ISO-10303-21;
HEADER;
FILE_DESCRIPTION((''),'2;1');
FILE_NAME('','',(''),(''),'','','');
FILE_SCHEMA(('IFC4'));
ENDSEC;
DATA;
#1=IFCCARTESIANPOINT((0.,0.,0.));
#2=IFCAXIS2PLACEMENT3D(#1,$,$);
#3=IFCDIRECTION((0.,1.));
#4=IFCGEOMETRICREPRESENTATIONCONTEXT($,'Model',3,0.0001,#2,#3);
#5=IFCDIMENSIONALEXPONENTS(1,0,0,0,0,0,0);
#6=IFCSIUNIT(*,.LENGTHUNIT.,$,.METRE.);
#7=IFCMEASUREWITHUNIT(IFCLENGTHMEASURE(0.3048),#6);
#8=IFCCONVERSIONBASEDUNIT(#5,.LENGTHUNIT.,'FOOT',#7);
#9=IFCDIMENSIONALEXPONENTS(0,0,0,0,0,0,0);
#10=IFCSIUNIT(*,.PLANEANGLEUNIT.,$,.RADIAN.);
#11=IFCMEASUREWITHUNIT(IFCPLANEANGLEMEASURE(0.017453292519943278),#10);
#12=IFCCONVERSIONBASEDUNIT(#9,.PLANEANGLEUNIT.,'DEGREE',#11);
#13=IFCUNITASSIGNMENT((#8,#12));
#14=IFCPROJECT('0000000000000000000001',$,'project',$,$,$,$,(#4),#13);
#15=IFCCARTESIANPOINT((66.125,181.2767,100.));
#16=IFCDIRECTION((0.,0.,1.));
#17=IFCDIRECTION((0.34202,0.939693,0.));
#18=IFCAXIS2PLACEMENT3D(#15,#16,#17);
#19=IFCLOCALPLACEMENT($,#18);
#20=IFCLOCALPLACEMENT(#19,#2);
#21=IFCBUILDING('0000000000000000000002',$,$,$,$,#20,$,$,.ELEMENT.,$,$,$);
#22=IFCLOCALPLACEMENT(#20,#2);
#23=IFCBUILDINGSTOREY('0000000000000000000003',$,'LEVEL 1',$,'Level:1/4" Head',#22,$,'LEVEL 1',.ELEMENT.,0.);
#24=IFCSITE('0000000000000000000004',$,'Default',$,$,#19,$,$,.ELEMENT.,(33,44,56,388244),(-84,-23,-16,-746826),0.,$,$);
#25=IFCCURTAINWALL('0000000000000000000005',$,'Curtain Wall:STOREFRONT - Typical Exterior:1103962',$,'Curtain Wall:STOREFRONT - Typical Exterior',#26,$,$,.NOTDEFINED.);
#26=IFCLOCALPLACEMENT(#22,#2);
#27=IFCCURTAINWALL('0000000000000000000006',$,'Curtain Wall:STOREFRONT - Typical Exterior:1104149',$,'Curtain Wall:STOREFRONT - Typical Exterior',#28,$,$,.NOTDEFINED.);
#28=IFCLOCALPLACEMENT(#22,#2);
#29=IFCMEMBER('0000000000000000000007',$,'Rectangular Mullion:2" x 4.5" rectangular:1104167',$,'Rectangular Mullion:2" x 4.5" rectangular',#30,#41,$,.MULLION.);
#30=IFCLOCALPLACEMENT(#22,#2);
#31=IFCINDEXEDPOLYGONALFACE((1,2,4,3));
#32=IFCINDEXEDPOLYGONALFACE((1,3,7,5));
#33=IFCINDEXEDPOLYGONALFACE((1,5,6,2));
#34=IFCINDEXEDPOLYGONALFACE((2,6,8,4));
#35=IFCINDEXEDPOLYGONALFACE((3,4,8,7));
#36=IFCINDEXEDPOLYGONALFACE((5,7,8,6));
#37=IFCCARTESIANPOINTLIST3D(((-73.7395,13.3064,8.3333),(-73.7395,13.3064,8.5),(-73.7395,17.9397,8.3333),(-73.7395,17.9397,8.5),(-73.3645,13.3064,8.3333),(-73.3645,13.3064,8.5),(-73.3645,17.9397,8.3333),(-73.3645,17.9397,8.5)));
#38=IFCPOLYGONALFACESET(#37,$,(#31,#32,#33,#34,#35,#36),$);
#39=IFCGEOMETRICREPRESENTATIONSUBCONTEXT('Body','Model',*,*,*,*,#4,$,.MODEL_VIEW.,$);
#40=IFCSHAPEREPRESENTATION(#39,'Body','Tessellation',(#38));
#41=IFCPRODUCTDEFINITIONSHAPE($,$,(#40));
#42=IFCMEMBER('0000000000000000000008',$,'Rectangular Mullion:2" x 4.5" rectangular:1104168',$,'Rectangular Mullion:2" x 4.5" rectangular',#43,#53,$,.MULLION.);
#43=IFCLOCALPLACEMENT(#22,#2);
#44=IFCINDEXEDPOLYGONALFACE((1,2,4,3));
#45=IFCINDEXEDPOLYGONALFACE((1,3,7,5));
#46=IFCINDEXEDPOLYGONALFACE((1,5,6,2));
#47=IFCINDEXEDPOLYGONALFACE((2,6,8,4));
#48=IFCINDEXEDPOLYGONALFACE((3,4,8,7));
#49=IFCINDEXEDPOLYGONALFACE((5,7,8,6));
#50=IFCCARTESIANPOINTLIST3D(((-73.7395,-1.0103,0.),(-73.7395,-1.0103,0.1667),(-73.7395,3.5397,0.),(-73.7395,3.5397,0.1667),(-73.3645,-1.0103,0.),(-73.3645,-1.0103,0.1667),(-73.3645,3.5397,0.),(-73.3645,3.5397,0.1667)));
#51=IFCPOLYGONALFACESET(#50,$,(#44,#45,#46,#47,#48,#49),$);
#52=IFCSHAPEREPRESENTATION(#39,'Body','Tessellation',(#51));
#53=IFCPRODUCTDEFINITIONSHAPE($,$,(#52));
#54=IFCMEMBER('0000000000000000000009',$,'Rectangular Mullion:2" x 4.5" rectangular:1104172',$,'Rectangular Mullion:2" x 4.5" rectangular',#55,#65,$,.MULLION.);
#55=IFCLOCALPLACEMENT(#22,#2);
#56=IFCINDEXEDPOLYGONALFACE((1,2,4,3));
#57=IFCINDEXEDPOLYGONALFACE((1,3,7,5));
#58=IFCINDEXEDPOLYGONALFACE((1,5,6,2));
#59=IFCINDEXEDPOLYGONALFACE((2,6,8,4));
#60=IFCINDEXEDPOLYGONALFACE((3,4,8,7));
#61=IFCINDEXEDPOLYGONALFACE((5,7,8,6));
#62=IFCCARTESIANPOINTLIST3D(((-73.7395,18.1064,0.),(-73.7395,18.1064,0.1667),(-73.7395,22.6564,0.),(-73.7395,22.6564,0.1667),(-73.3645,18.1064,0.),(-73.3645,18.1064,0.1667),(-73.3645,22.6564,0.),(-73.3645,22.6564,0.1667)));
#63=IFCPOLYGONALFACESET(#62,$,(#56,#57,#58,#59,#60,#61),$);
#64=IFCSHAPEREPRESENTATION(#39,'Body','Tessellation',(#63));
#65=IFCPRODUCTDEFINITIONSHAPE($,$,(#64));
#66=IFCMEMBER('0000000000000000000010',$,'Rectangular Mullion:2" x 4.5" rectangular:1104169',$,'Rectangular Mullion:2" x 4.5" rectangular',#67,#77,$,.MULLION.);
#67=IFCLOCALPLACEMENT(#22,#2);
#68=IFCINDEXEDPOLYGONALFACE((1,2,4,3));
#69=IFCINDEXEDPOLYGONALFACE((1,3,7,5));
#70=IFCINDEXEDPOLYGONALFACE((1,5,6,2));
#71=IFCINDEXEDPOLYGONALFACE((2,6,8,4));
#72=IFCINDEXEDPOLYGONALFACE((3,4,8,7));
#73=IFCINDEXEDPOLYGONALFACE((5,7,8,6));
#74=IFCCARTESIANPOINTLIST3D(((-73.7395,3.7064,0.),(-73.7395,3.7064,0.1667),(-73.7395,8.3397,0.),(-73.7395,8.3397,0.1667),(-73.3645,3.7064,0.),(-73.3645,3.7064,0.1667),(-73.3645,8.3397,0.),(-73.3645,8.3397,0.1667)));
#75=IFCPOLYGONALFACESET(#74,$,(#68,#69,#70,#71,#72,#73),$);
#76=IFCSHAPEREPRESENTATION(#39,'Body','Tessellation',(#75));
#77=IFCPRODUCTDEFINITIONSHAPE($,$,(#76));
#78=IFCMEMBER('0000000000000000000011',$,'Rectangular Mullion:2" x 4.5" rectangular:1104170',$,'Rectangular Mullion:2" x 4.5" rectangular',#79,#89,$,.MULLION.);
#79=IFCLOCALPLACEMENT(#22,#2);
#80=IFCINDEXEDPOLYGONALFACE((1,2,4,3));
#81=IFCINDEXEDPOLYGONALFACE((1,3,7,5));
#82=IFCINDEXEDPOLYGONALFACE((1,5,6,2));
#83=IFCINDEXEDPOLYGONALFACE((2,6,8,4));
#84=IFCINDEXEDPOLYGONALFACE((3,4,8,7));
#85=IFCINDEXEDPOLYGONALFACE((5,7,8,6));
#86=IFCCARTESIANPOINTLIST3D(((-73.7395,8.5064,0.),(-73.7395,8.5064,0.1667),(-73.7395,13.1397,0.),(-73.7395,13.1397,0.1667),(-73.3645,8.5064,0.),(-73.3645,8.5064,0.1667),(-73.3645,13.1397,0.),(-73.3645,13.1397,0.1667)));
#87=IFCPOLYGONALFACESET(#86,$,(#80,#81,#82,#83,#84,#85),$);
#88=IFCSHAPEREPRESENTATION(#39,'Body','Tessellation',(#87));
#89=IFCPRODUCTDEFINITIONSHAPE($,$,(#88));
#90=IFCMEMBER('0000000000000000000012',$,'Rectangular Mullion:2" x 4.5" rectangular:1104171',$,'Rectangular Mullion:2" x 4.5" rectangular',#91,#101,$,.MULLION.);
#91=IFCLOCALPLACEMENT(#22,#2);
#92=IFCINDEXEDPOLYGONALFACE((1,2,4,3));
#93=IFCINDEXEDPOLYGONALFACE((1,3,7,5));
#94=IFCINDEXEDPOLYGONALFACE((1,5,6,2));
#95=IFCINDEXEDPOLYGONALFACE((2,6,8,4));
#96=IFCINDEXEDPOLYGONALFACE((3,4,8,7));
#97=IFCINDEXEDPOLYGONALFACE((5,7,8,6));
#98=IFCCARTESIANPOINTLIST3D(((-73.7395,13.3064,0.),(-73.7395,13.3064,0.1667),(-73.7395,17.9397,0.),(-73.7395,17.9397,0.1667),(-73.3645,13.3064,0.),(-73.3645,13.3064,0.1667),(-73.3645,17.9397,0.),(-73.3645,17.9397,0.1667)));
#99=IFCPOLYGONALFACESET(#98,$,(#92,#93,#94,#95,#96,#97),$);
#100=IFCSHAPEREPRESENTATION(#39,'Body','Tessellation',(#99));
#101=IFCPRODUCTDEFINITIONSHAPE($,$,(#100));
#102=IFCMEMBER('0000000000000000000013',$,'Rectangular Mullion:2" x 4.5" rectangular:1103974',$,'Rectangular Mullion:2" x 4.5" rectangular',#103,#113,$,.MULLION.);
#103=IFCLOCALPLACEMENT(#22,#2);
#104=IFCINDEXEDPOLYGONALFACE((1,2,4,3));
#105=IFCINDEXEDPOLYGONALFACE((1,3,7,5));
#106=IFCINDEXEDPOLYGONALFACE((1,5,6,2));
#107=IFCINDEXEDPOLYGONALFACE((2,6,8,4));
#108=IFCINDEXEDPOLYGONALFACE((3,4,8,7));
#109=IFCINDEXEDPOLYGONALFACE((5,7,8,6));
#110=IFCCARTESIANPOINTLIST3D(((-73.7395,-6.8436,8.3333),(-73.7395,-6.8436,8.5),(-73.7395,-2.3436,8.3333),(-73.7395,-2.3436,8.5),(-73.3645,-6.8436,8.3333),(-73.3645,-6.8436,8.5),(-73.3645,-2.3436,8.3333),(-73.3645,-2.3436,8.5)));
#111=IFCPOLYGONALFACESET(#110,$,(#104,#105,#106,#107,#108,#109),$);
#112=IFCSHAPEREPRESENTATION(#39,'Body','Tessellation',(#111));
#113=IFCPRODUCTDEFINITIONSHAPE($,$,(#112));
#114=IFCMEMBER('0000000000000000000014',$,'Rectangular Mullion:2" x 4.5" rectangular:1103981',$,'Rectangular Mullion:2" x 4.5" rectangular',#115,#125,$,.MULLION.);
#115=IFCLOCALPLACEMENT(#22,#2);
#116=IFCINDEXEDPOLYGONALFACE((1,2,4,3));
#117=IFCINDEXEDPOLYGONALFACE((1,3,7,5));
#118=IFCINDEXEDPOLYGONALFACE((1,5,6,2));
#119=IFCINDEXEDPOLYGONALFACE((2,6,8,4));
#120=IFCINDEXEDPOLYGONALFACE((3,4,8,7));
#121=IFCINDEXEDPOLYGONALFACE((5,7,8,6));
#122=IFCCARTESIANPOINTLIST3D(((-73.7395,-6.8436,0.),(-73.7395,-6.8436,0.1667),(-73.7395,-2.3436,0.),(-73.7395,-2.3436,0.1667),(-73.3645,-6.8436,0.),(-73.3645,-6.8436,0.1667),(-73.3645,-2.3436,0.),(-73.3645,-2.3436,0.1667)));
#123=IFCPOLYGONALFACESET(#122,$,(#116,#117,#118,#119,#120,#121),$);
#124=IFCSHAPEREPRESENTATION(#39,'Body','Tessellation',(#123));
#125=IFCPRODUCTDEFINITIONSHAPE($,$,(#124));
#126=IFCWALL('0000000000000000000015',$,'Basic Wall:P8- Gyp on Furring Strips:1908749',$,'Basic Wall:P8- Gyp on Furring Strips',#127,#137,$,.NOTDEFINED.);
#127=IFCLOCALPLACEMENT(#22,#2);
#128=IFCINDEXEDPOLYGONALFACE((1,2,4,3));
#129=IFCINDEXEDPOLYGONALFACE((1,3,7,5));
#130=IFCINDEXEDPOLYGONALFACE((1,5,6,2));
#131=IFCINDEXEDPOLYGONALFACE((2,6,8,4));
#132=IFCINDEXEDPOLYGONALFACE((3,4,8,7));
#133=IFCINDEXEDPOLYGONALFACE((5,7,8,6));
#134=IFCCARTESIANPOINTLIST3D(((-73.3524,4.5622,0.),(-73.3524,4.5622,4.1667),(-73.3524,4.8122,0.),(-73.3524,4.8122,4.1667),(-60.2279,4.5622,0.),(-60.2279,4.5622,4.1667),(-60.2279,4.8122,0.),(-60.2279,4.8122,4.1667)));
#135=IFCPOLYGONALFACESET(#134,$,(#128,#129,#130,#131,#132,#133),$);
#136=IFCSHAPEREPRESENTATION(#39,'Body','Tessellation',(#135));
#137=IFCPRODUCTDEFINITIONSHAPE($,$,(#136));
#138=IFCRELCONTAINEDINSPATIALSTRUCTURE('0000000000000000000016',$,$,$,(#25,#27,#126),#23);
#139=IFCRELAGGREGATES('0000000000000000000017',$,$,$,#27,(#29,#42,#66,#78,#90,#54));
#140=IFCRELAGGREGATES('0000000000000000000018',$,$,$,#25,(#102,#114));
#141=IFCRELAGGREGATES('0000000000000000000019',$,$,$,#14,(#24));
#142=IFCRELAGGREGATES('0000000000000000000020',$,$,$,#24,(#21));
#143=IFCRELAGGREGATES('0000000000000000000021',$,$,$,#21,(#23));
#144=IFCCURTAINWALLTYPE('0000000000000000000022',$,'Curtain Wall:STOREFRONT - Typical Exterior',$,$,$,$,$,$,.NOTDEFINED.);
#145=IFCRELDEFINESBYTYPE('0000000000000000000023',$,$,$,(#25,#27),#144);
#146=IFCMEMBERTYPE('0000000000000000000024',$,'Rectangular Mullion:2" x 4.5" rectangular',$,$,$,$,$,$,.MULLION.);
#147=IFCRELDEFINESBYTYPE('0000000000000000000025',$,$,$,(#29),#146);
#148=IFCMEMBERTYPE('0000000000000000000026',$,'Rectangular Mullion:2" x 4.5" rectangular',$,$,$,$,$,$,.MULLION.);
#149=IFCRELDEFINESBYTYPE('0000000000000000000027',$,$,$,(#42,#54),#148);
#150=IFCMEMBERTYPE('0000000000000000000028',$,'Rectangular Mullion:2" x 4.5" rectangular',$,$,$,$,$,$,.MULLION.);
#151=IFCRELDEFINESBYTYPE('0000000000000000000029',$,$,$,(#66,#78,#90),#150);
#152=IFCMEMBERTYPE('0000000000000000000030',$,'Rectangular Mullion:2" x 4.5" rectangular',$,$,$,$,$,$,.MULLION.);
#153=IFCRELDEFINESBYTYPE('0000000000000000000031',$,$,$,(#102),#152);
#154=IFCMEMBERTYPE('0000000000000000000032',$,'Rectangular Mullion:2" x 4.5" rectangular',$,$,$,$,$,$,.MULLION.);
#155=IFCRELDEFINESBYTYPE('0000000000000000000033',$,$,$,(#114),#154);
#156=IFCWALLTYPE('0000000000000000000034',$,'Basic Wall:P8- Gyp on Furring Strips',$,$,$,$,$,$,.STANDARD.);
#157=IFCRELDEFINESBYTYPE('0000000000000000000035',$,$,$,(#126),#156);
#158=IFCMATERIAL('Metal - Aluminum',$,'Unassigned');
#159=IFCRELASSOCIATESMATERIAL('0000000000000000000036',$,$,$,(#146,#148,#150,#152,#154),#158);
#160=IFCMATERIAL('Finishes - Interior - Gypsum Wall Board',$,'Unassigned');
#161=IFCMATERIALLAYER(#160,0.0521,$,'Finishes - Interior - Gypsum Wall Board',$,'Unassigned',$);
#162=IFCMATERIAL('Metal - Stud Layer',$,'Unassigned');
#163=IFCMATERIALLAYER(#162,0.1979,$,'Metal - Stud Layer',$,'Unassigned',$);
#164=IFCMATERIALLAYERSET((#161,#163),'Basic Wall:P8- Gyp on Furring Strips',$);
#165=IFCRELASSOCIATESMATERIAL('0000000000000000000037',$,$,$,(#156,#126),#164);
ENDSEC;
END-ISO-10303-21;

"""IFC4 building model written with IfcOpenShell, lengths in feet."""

from ifc_helpers import new_model, entity, si_unit, converted_unit, direction, frame, frame_2d, origin, origin_2d_with_axis, place, context, subcontext, project, spatial, rectangle, extrude, source, transform, mapped, material, layer, layer_set, layer_usage, material_profile, profile_set, type_object, type_shapes, element, aggregate, save


model = new_model("IFC4")

# Units and contexts
model_context = context("Model", 3, precision=0.0001, world=origin(), true_north=direction((0.0, 1.0)))
body_context = subcontext(model_context, "Body", "Model", "MODEL_VIEW")
ifc_project = project(units=[converted_unit("LENGTHUNIT", "FOOT", entity("IfcLengthMeasure", 0.3048), si_unit("LENGTHUNIT", "METRE"), dimensions=[1, 0, 0, 0, 0, 0, 0]), converted_unit("PLANEANGLEUNIT", "DEGREE", entity("IfcPlaneAngleMeasure", 0.017453292519943278), si_unit("PLANEANGLEUNIT", "RADIAN"), dimensions=[0, 0, 0, 0, 0, 0, 0])], contexts=[model_context])

# Site, building, storey
site_placement = place(None, frame((66.125, 181.2767, 100.0), z_axis=(0.0, 0.0, 1.0), x_axis=(0.34202, 0.939693, 0.0)))
site = spatial("IfcSite", under=ifc_project, at=site_placement, Name="Default", CompositionType="ELEMENT", RefLatitude=(33, 44, 56, 388244), RefLongitude=(-84, -23, -16, -746826), RefElevation=0.0)
building_placement = place(site_placement, origin())
building = spatial("IfcBuilding", under=site, at=building_placement, CompositionType="ELEMENT")
storey_placement = place(building_placement, origin())
storey = spatial("IfcBuildingStorey", under=building, at=storey_placement, Name="LEVEL 1", ObjectType="Level:1/4\" Head", LongName="LEVEL 1", CompositionType="ELEMENT", Elevation=0.0)

# Curtain wall
curtain_wall_type = type_object("IfcCurtainWallType", Name="Curtain Wall:STOREFRONT - Typical Exterior", PredefinedType="NOTDEFINED")
curtain_wall_1_placement = place(storey_placement, origin())
curtain_wall_1 = element("IfcCurtainWall", 1, at=curtain_wall_1_placement, inside=storey, type_object=curtain_wall_type, Name="Curtain Wall:STOREFRONT - Typical Exterior:1103962", ObjectType="Curtain Wall:STOREFRONT - Typical Exterior", PredefinedType="NOTDEFINED")
ifc_material_1 = material(Name="Metal - Aluminum", Category="Unassigned")
ifc_material_profile = material_profile(ifc_material_1, rectangle(XDim=0.1667, YDim=0.375, at=origin_2d_with_axis()), Name="2\" x 4.5\" rectangular")
ifc_profile_set = profile_set([ifc_material_profile], Name="2\" x 4.5\" rectangular")

# Curtain wall
curtain_wall_2_placement = place(storey_placement, origin())
curtain_wall_2 = element("IfcCurtainWall", 2, at=curtain_wall_2_placement, inside=storey, type_object=curtain_wall_type, Name="Curtain Wall:STOREFRONT - Typical Exterior:1104149", ObjectType="Curtain Wall:STOREFRONT - Typical Exterior", PredefinedType="NOTDEFINED")

# Members
member_type_1 = type_object("IfcMemberType", Name="Rectangular Mullion:2\" x 4.5\" rectangular", PredefinedType="MULLION", material=ifc_profile_set)
shared_shape_1 = source(origin(), body_context, "Body", "SweptSolid", [
    extrude(rectangle(XDim=0.1667, YDim=0.375, at=origin_2d_with_axis()), frame((-0.0833, 0.0, -4.6333), z_axis=(0.0, 0.0, 1.0), x_axis=(-1.0, 0.0, 0.0)), (0.0, 0.0, 1.0), 4.6333),
])
type_shapes(member_type_1, [shared_shape_1])
member_1_placement = place(curtain_wall_2_placement, frame((-73.552, 17.9397, 8.5), z_axis=(0.0, 1.0, 0.0), x_axis=(0.0, 0.0, 1.0)))
member_1 = element("IfcMember", 3, at=member_1_placement, type_object=member_type_1, Name="Rectangular Mullion:2\" x 4.5\" rectangular:1104167", ObjectType="Rectangular Mullion:2\" x 4.5\" rectangular", PredefinedType="MULLION", context=body_context, shape_type="MappedRepresentation", body=[
    mapped(shared_shape_1, transform((0.0, 0.0, 0.0), scale=1.0)),
])
member_type_2 = type_object("IfcMemberType", Name="Rectangular Mullion:2\" x 4.5\" rectangular", PredefinedType="MULLION", material=ifc_profile_set)
shared_shape_2 = source(origin(), body_context, "Body", "SweptSolid", [
    extrude(rectangle(XDim=0.1667, YDim=0.375, at=origin_2d_with_axis()), frame((-0.0833, 0.0, -4.55), z_axis=(0.0, 0.0, 1.0), x_axis=(-1.0, 0.0, 0.0)), (0.0, 0.0, 1.0), 4.55),
])
type_shapes(member_type_2, [shared_shape_2])
member_2_placement = place(curtain_wall_2_placement, frame((-73.552, -1.0103, 0.0), z_axis=(0.0, -1.0, 0.0), x_axis=(0.0, 0.0, -1.0)))
member_2 = element("IfcMember", 4, at=member_2_placement, type_object=member_type_2, Name="Rectangular Mullion:2\" x 4.5\" rectangular:1104168", ObjectType="Rectangular Mullion:2\" x 4.5\" rectangular", PredefinedType="MULLION", context=body_context, shape_type="MappedRepresentation", body=[
    mapped(shared_shape_2, transform((0.0, 0.0, 0.0), scale=1.0)),
])
member_3_placement = place(curtain_wall_2_placement, frame((-73.552, 18.1064, 0.0), z_axis=(0.0, -1.0, 0.0), x_axis=(0.0, 0.0, -1.0)))
member_3 = element("IfcMember", 5, at=member_3_placement, type_object=member_type_2, Name="Rectangular Mullion:2\" x 4.5\" rectangular:1104172", ObjectType="Rectangular Mullion:2\" x 4.5\" rectangular", PredefinedType="MULLION", context=body_context, shape_type="MappedRepresentation", body=[
    mapped(shared_shape_2, transform((0.0, 0.0, 0.0), scale=1.0)),
])
member_type_3 = type_object("IfcMemberType", Name="Rectangular Mullion:2\" x 4.5\" rectangular", PredefinedType="MULLION", material=ifc_profile_set)
shared_shape_3 = source(origin(), body_context, "Body", "SweptSolid", [
    extrude(rectangle(XDim=0.1667, YDim=0.375, at=origin_2d_with_axis()), frame((-0.0833, 0.0, -4.6333), z_axis=(0.0, 0.0, 1.0), x_axis=(-1.0, 0.0, 0.0)), (0.0, 0.0, 1.0), 4.6333),
])
type_shapes(member_type_3, [shared_shape_3])
member_4_placement = place(curtain_wall_2_placement, frame((-73.552, 3.7064, 0.0), z_axis=(0.0, -1.0, 0.0), x_axis=(0.0, 0.0, -1.0)))
member_4 = element("IfcMember", 6, at=member_4_placement, type_object=member_type_3, Name="Rectangular Mullion:2\" x 4.5\" rectangular:1104169", ObjectType="Rectangular Mullion:2\" x 4.5\" rectangular", PredefinedType="MULLION", context=body_context, shape_type="MappedRepresentation", body=[
    mapped(shared_shape_3, transform((0.0, 0.0, 0.0), scale=1.0)),
])
member_5_placement = place(curtain_wall_2_placement, frame((-73.552, 8.5064, 0.0), z_axis=(0.0, -1.0, 0.0), x_axis=(0.0, 0.0, -1.0)))
member_5 = element("IfcMember", 7, at=member_5_placement, type_object=member_type_3, Name="Rectangular Mullion:2\" x 4.5\" rectangular:1104170", ObjectType="Rectangular Mullion:2\" x 4.5\" rectangular", PredefinedType="MULLION", context=body_context, shape_type="MappedRepresentation", body=[
    mapped(shared_shape_3, transform((0.0, 0.0, 0.0), scale=1.0)),
])
member_6_placement = place(curtain_wall_2_placement, frame((-73.552, 13.3064, 0.0), z_axis=(0.0, -1.0, 0.0), x_axis=(0.0, 0.0, -1.0)))
member_6 = element("IfcMember", 8, at=member_6_placement, type_object=member_type_3, Name="Rectangular Mullion:2\" x 4.5\" rectangular:1104171", ObjectType="Rectangular Mullion:2\" x 4.5\" rectangular", PredefinedType="MULLION", context=body_context, shape_type="MappedRepresentation", body=[
    mapped(shared_shape_3, transform((0.0, 0.0, 0.0), scale=1.0)),
])
member_type_4 = type_object("IfcMemberType", Name="Rectangular Mullion:2\" x 4.5\" rectangular", PredefinedType="MULLION", material=ifc_profile_set)
shared_shape_4 = source(origin(), body_context, "Body", "SweptSolid", [
    extrude(rectangle(XDim=0.1667, YDim=0.375, at=origin_2d_with_axis()), frame((-0.0833, 0.0, -4.5), z_axis=(0.0, 0.0, 1.0), x_axis=(-1.0, 0.0, 0.0)), (0.0, 0.0, 1.0), 4.5),
])
type_shapes(member_type_4, [shared_shape_4])
member_7_placement = place(curtain_wall_1_placement, frame((-73.552, -2.3436, 8.5), z_axis=(0.0, 1.0, 0.0), x_axis=(0.0, 0.0, 1.0)))
member_7 = element("IfcMember", 9, at=member_7_placement, type_object=member_type_4, Name="Rectangular Mullion:2\" x 4.5\" rectangular:1103974", ObjectType="Rectangular Mullion:2\" x 4.5\" rectangular", PredefinedType="MULLION", context=body_context, shape_type="MappedRepresentation", body=[
    mapped(shared_shape_4, transform((0.0, 0.0, 0.0), scale=1.0)),
])
member_type_5 = type_object("IfcMemberType", Name="Rectangular Mullion:2\" x 4.5\" rectangular", PredefinedType="MULLION", material=ifc_profile_set)
shared_shape_5 = source(origin(), body_context, "Body", "SweptSolid", [
    extrude(rectangle(XDim=0.1667, YDim=0.375, at=origin_2d_with_axis()), frame((-0.0833, 0.0, -4.5), z_axis=(0.0, 0.0, 1.0), x_axis=(-1.0, 0.0, 0.0)), (0.0, 0.0, 1.0), 4.5),
])
type_shapes(member_type_5, [shared_shape_5])
member_8_placement = place(curtain_wall_1_placement, frame((-73.552, -6.8436, 0.0), z_axis=(0.0, -1.0, 0.0), x_axis=(0.0, 0.0, -1.0)))
member_8 = element("IfcMember", 10, at=member_8_placement, type_object=member_type_5, Name="Rectangular Mullion:2\" x 4.5\" rectangular:1103981", ObjectType="Rectangular Mullion:2\" x 4.5\" rectangular", PredefinedType="MULLION", context=body_context, shape_type="MappedRepresentation", body=[
    mapped(shared_shape_5, transform((0.0, 0.0, 0.0), scale=1.0)),
])

aggregate(curtain_wall_2, [member_1, member_2, member_4, member_5, member_6, member_3])
aggregate(curtain_wall_1, [member_7, member_8])

# Wall
ifc_material_2 = material(Name="Finishes - Interior - Gypsum Wall Board", Category="Unassigned")
ifc_layer_1 = layer(ifc_material_2, 0.0521, Name="Finishes - Interior - Gypsum Wall Board", Category="Unassigned")
ifc_material_3 = material(Name="Metal - Stud Layer", Category="Unassigned")
ifc_layer_2 = layer(ifc_material_3, 0.1979, Name="Metal - Stud Layer", Category="Unassigned")
ifc_layer_set = layer_set([ifc_layer_1, ifc_layer_2], Name="Basic Wall:P8- Gyp on Furring Strips")
ifc_layer_usage = layer_usage(ifc_layer_set, "AXIS2", "NEGATIVE", 0.125)
wall_type = type_object("IfcWallType", Name="Basic Wall:P8- Gyp on Furring Strips", PredefinedType="STANDARD", material=ifc_layer_set)
wall_placement = place(storey_placement, frame((-73.3524, 4.6872, 0.0)))
element("IfcWall", 11, at=wall_placement, inside=storey, type_object=wall_type, material=ifc_layer_usage, Name="Basic Wall:P8- Gyp on Furring Strips:1908749", ObjectType="Basic Wall:P8- Gyp on Furring Strips", PredefinedType="NOTDEFINED", context=body_context, shape_type="SweptSolid", body=[
    extrude(rectangle(XDim=13.1245, YDim=0.25, at=frame_2d((6.5622, 0.0), x_axis=(-1.0, 0.0))), origin(), (0.0, 0.0, 1.0), 4.1667),
])

save(model, "model.ifc")
